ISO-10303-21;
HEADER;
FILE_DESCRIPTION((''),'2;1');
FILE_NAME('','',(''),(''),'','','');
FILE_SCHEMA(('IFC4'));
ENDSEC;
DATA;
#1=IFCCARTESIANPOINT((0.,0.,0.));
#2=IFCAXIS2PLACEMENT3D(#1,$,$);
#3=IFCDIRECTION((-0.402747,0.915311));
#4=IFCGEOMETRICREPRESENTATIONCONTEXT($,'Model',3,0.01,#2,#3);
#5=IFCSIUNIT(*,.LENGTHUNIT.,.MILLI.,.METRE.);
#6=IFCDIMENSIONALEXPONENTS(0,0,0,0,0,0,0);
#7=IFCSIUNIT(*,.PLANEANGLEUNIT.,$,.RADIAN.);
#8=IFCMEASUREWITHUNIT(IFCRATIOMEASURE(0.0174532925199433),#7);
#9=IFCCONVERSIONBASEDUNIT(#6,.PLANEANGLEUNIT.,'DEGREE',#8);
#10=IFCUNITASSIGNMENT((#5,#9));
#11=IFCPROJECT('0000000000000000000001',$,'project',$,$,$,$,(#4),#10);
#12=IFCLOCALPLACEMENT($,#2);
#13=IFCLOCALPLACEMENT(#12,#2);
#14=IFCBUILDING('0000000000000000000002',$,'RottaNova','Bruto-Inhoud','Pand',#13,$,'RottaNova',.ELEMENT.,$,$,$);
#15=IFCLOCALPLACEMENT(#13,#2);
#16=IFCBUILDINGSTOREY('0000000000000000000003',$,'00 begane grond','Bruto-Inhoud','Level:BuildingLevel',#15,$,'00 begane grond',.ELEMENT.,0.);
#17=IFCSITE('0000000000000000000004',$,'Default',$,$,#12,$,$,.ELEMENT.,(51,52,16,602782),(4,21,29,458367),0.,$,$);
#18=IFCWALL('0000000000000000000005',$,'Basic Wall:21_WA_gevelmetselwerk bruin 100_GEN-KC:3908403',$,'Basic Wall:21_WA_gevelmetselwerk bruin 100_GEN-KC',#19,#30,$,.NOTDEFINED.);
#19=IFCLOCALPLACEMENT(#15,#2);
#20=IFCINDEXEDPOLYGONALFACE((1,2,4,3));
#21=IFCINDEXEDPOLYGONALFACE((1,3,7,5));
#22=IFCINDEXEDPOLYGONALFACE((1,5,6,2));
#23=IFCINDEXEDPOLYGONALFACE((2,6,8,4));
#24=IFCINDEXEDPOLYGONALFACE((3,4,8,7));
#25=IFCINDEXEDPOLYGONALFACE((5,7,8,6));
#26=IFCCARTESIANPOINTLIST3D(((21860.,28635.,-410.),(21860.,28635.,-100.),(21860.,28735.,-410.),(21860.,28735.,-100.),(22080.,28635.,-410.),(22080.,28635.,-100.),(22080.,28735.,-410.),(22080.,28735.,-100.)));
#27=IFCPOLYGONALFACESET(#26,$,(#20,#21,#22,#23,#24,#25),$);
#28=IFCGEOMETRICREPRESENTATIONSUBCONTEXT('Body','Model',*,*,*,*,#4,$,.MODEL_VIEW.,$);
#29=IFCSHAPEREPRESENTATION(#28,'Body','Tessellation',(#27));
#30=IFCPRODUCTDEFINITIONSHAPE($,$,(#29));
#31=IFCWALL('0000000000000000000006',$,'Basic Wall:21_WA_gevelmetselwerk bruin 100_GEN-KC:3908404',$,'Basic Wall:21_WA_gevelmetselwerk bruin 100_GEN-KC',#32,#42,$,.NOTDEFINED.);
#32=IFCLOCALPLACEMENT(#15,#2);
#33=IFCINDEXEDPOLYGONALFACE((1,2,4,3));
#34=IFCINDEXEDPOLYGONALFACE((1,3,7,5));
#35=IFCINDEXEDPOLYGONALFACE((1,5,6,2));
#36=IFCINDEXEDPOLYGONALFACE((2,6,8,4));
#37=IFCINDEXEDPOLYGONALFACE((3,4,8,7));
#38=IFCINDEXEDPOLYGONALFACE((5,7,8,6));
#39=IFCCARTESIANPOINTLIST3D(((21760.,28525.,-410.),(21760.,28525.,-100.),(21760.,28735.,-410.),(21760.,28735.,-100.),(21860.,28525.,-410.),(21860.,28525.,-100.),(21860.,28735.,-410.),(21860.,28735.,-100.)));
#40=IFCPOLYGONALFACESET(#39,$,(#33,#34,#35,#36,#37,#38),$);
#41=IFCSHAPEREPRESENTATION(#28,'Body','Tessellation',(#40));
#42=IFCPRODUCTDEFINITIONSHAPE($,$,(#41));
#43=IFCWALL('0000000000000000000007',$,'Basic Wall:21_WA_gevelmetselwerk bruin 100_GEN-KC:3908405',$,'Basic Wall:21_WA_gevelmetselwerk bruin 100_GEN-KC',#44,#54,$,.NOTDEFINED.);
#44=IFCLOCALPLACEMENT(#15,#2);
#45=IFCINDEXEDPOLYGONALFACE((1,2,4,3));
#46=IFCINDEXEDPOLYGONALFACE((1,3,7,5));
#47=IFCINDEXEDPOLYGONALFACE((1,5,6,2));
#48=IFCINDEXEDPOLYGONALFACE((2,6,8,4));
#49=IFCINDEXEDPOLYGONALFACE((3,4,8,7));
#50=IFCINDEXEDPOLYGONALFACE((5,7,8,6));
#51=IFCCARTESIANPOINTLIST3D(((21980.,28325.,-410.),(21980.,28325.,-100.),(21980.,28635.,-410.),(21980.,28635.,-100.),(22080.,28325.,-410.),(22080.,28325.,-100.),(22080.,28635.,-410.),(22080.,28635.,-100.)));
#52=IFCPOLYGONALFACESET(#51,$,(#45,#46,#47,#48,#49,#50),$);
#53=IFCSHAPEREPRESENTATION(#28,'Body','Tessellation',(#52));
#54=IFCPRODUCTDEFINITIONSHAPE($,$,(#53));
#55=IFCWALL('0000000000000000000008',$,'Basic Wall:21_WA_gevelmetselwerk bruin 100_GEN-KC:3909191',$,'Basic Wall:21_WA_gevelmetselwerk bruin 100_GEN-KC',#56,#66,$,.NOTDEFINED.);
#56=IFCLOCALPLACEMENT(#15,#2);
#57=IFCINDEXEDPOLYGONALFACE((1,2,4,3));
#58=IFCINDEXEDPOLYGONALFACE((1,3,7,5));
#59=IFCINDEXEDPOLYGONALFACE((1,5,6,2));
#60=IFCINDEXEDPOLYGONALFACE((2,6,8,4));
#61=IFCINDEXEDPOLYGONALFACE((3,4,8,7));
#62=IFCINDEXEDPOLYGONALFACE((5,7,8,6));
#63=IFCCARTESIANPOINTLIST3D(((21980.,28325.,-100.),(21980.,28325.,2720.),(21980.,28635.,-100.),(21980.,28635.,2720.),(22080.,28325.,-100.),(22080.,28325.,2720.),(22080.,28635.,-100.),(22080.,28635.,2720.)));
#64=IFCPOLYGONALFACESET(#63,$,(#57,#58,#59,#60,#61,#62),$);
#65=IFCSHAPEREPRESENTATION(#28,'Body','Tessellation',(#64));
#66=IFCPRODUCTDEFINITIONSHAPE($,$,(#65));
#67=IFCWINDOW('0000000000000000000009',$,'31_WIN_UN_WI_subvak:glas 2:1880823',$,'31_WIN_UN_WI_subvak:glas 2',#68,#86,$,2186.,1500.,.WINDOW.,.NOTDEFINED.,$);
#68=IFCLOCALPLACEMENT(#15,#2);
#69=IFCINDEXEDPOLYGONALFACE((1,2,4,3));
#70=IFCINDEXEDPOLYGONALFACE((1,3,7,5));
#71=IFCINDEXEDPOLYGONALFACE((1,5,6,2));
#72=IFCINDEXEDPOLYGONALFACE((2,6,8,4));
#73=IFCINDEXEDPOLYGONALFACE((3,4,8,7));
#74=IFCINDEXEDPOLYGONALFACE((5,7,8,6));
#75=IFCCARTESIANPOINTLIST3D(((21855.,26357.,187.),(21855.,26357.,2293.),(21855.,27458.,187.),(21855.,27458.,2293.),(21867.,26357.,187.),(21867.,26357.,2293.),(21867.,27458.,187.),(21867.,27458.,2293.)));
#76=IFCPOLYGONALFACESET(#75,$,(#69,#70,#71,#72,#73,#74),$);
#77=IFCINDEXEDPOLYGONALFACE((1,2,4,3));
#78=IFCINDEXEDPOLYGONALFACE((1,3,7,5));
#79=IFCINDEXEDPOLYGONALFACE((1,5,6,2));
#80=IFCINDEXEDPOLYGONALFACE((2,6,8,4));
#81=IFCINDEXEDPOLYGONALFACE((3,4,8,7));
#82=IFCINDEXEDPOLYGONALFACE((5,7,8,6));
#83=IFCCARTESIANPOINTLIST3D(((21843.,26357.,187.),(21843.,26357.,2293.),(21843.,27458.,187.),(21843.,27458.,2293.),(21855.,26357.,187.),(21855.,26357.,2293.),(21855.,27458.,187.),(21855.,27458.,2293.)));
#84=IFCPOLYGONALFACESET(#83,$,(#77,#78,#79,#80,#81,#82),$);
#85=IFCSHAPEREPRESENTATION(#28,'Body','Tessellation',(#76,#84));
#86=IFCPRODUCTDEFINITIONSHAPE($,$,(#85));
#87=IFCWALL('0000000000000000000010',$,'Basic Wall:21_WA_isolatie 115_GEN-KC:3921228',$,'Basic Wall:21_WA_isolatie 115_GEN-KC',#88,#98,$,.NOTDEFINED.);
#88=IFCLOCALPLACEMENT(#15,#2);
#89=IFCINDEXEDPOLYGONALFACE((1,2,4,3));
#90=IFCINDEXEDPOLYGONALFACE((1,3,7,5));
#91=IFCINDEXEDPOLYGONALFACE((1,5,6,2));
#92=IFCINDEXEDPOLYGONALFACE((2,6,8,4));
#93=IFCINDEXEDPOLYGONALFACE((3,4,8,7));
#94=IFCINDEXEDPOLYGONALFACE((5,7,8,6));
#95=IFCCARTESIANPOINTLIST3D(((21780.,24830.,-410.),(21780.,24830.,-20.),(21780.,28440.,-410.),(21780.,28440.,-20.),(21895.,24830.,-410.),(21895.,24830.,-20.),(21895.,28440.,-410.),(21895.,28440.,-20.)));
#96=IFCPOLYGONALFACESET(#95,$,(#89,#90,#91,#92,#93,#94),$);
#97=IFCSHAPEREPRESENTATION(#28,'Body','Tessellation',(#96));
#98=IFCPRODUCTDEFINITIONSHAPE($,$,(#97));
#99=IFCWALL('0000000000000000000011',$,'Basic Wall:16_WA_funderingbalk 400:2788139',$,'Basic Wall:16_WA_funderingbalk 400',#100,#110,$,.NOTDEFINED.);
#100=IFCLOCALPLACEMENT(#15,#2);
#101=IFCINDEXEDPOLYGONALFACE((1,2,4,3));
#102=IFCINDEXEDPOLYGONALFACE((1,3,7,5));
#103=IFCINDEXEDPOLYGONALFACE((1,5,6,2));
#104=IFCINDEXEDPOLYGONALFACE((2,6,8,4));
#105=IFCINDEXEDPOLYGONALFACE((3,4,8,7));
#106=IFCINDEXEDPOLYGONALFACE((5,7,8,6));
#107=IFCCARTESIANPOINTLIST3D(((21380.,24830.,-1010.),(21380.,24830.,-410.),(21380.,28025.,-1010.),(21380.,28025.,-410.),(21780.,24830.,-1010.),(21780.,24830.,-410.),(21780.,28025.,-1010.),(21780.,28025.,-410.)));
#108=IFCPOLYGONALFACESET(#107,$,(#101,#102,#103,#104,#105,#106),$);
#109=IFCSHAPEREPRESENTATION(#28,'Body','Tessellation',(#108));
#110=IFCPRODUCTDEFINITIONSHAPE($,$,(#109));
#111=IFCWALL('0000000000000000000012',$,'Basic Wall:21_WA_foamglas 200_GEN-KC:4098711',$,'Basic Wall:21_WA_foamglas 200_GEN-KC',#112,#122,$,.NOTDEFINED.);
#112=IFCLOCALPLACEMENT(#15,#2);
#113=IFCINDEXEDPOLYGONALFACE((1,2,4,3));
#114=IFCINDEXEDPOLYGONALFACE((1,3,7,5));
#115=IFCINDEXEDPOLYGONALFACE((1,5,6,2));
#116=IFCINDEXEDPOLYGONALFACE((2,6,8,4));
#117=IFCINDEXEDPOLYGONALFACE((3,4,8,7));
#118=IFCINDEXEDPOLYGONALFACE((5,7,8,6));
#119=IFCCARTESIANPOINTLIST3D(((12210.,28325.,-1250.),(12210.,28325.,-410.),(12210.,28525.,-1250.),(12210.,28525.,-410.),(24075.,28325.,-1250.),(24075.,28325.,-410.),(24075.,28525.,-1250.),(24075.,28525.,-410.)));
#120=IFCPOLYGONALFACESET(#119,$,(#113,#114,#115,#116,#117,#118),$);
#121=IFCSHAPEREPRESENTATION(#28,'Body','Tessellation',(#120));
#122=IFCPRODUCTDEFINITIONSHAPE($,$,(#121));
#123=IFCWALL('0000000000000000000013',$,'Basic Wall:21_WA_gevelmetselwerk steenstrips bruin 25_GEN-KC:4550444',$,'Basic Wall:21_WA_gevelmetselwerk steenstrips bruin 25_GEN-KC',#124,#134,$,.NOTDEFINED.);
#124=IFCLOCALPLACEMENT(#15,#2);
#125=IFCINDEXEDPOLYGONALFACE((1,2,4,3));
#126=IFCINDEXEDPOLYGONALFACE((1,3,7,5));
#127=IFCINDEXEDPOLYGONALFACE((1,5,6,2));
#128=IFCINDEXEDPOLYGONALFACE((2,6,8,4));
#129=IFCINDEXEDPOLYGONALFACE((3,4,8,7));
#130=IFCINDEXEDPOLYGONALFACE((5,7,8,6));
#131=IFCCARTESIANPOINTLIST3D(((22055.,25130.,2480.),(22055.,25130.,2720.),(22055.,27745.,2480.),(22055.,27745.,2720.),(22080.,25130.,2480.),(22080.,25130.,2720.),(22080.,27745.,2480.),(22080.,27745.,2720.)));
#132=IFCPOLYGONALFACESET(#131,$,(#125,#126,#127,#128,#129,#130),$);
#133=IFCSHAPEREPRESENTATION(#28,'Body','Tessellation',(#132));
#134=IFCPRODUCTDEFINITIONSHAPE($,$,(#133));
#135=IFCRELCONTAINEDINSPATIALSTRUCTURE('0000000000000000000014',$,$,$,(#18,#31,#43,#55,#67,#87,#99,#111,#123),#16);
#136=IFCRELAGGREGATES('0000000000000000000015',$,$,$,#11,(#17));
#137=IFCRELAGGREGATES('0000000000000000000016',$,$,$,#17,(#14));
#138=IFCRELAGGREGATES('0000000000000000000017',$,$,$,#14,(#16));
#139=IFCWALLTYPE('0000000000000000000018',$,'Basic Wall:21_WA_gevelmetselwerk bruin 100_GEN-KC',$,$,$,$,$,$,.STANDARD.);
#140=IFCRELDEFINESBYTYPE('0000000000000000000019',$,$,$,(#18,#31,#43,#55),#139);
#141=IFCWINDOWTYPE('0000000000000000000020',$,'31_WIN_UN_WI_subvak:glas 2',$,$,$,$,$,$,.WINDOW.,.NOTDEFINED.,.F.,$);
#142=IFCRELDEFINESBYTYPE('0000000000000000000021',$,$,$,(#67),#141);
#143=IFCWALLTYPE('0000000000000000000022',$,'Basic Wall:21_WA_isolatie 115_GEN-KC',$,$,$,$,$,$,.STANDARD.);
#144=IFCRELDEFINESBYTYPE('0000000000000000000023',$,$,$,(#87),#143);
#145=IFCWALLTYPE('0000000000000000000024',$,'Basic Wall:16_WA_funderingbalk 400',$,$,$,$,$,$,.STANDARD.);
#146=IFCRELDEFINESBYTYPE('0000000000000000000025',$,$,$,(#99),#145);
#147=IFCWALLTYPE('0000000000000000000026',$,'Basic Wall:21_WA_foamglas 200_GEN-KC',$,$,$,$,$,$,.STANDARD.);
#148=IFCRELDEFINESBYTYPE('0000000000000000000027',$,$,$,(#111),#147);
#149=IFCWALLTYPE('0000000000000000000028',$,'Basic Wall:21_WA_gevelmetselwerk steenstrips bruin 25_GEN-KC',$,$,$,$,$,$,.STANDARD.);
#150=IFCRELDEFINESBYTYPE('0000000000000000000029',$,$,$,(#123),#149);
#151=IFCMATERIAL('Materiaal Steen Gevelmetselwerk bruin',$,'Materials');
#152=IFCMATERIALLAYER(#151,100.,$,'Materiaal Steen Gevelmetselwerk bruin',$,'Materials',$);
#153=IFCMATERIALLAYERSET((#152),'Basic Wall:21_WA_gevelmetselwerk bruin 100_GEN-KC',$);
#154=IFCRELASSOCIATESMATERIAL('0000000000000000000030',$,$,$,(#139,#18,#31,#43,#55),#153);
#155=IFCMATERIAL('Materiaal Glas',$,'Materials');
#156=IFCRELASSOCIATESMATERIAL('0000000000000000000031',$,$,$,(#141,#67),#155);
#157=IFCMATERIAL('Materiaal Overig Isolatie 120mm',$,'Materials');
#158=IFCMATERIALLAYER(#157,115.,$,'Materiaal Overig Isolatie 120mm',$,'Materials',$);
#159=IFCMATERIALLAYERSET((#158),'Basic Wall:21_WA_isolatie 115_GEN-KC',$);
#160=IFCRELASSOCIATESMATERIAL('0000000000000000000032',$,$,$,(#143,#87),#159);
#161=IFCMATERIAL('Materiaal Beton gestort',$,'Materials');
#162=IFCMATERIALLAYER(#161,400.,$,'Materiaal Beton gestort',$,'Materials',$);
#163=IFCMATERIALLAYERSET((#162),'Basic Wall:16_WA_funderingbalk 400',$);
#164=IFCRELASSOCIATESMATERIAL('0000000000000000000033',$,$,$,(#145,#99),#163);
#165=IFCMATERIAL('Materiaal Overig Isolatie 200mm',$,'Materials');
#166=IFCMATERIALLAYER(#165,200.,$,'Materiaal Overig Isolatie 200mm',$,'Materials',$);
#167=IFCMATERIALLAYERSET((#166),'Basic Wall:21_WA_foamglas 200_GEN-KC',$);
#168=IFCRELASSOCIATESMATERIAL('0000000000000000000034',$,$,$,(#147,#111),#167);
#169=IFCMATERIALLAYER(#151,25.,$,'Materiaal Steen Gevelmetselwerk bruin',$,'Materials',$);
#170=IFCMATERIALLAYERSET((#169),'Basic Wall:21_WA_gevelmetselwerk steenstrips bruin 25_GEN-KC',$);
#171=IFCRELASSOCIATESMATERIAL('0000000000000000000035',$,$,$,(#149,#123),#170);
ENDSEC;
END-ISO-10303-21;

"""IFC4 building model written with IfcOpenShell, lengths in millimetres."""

from ifc_helpers import new_model, entity, si_unit, converted_unit, direction, frame, frame_2d, origin, origin_2d_with_axis, place, context, subcontext, project, spatial, rectangle, extrude, source, transform, mapped, material, layer, layer_set, type_object, type_shapes, element, save


model = new_model("IFC4")

# Units and contexts
model_context = context("Model", 3, precision=0.01, world=origin(), true_north=direction((-0.402747, 0.915311)))
body_context = subcontext(model_context, "Body", "Model", "MODEL_VIEW")
ifc_project = project(units=[si_unit("LENGTHUNIT", "METRE", prefix="MILLI"), converted_unit("PLANEANGLEUNIT", "DEGREE", entity("IfcRatioMeasure", 0.0174532925199433), si_unit("PLANEANGLEUNIT", "RADIAN"), dimensions=[0, 0, 0, 0, 0, 0, 0])], contexts=[model_context])

# Site, building, storey
site_placement = place(None, origin())
site = spatial("IfcSite", under=ifc_project, at=site_placement, Name="Default", CompositionType="ELEMENT", RefLatitude=(51, 52, 16, 602782), RefLongitude=(4, 21, 29, 458367), RefElevation=0.0)
building_placement = place(site_placement, origin())
building = spatial("IfcBuilding", under=site, at=building_placement, Name="RottaNova", Description="Bruto-Inhoud", ObjectType="Pand", LongName="RottaNova", CompositionType="ELEMENT")
storey_placement = place(building_placement, origin())
storey = spatial("IfcBuildingStorey", under=building, at=storey_placement, Name="00 begane grond", Description="Bruto-Inhoud", ObjectType="Level:BuildingLevel", LongName="00 begane grond", CompositionType="ELEMENT", Elevation=0.0)

# Walls
ifc_material_1 = material(Name="Materiaal Steen Gevelmetselwerk bruin", Category="Materials")
ifc_layer_1 = layer(ifc_material_1, 100.0, Name="Materiaal Steen Gevelmetselwerk bruin", Category="Materials")
ifc_layer_set_1 = layer_set([ifc_layer_1], Name="Basic Wall:21_WA_gevelmetselwerk bruin 100_GEN-KC")
wall_type_1 = type_object("IfcWallType", Name="Basic Wall:21_WA_gevelmetselwerk bruin 100_GEN-KC", PredefinedType="STANDARD", material=ifc_layer_set_1)
wall_1_placement = place(storey_placement, frame((22080.0, 28685.0, -410.0), z_axis=(0.0, 0.0, 1.0), x_axis=(-1.0, 0.0, 0.0)))
element("IfcWall", 1, at=wall_1_placement, inside=storey, type_object=wall_type_1, material=ifc_layer_set_1, Name="Basic Wall:21_WA_gevelmetselwerk bruin 100_GEN-KC:3908403", ObjectType="Basic Wall:21_WA_gevelmetselwerk bruin 100_GEN-KC", PredefinedType="NOTDEFINED", context=body_context, shape_type="SweptSolid", body=[
    extrude(rectangle(XDim=220.0, YDim=100.0, at=frame_2d((110.0, 0.0), x_axis=(-1.0, 0.0))), origin(), (0.0, 0.0, 1.0), 310.0),
])
wall_2_placement = place(storey_placement, frame((21810.0, 28735.0, -410.0), z_axis=(0.0, 0.0, 1.0), x_axis=(0.0, -1.0, 0.0)))
element("IfcWall", 2, at=wall_2_placement, inside=storey, type_object=wall_type_1, material=ifc_layer_set_1, Name="Basic Wall:21_WA_gevelmetselwerk bruin 100_GEN-KC:3908404", ObjectType="Basic Wall:21_WA_gevelmetselwerk bruin 100_GEN-KC", PredefinedType="NOTDEFINED", context=body_context, shape_type="SweptSolid", body=[
    extrude(rectangle(XDim=210.0, YDim=100.0, at=frame_2d((105.0, 0.0), x_axis=(-1.0, 0.0))), origin(), (0.0, 0.0, 1.0), 310.0),
])
wall_3_placement = place(storey_placement, frame((22030.0, 28325.0, -410.0), z_axis=(0.0, 0.0, 1.0), x_axis=(0.0, 1.0, 0.0)))
element("IfcWall", 3, at=wall_3_placement, inside=storey, type_object=wall_type_1, material=ifc_layer_set_1, Name="Basic Wall:21_WA_gevelmetselwerk bruin 100_GEN-KC:3908405", ObjectType="Basic Wall:21_WA_gevelmetselwerk bruin 100_GEN-KC", PredefinedType="NOTDEFINED", context=body_context, shape_type="SweptSolid", body=[
    extrude(rectangle(XDim=310.0, YDim=100.0, at=frame_2d((155.0, 0.0), x_axis=(-1.0, 0.0))), origin(), (0.0, 0.0, 1.0), 310.0),
])
wall_4_placement = place(storey_placement, frame((22030.0, 28325.0, -100.0), z_axis=(0.0, 0.0, 1.0), x_axis=(0.0, 1.0, 0.0)))
element("IfcWall", 4, at=wall_4_placement, inside=storey, type_object=wall_type_1, material=ifc_layer_set_1, Name="Basic Wall:21_WA_gevelmetselwerk bruin 100_GEN-KC:3909191", ObjectType="Basic Wall:21_WA_gevelmetselwerk bruin 100_GEN-KC", PredefinedType="NOTDEFINED", context=body_context, shape_type="SweptSolid", body=[
    extrude(rectangle(XDim=310.0, YDim=100.0, at=frame_2d((155.0, 0.0), x_axis=(-1.0, 0.0))), origin(), (0.0, 0.0, 1.0), 2820.0),
])

# Window
ifc_material_2 = material(Name="Materiaal Glas", Category="Materials")
window_type = type_object("IfcWindowType", Name="31_WIN_UN_WI_subvak:glas 2", ParameterTakesPrecedence=False, PartitioningType="NOTDEFINED", PredefinedType="WINDOW", material=ifc_material_2)
shared_shape_1 = source(origin(), body_context, "Body", "SweptSolid", [
    extrude(rectangle(XDim=12.0, YDim=1101.0, at=frame_2d((0.0, 0.0), x_axis=(1.0, 0.0))), frame((0.0, 6.0, 0.0), z_axis=(0.0, 0.0, 1.0), x_axis=(0.0, -1.0, 0.0)), (0.0, 0.0, 1.0), 2106.0),
    extrude(rectangle(XDim=12.0, YDim=1101.0, at=origin_2d_with_axis()), frame((0.0, -6.0, 0.0), z_axis=(0.0, 0.0, 1.0), x_axis=(0.0, -1.0, 0.0)), (0.0, 0.0, 1.0), 2106.0),
])
type_shapes(window_type, [shared_shape_1])
window_placement = place(storey_placement, frame((21855.0, 26907.5, 187.0), z_axis=(0.0, 0.0, 1.0), x_axis=(0.0, -1.0, 0.0)))
element("IfcWindow", 5, at=window_placement, inside=storey, type_object=window_type, material=ifc_material_2, Name="31_WIN_UN_WI_subvak:glas 2:1880823", ObjectType="31_WIN_UN_WI_subvak:glas 2", OverallHeight=2186.0, OverallWidth=1500.0, PartitioningType="NOTDEFINED", PredefinedType="WINDOW", context=body_context, shape_type="MappedRepresentation", body=[
    mapped(shared_shape_1, transform((0.0, 0.0, 0.0), scale=1.0)),
])

# Walls
ifc_material_3 = material(Name="Materiaal Overig Isolatie 120mm", Category="Materials")
ifc_layer_2 = layer(ifc_material_3, 115.0, Name="Materiaal Overig Isolatie 120mm", Category="Materials")
ifc_layer_set_2 = layer_set([ifc_layer_2], Name="Basic Wall:21_WA_isolatie 115_GEN-KC")
wall_type_2 = type_object("IfcWallType", Name="Basic Wall:21_WA_isolatie 115_GEN-KC", PredefinedType="STANDARD", material=ifc_layer_set_2)
wall_5_placement = place(storey_placement, frame((21837.5, 28440.0, -410.0), z_axis=(0.0, 0.0, 1.0), x_axis=(0.0, -1.0, 0.0)))
element("IfcWall", 6, at=wall_5_placement, inside=storey, type_object=wall_type_2, material=ifc_layer_set_2, Name="Basic Wall:21_WA_isolatie 115_GEN-KC:3921228", ObjectType="Basic Wall:21_WA_isolatie 115_GEN-KC", PredefinedType="NOTDEFINED", context=body_context, shape_type="SweptSolid", body=[
    extrude(rectangle(XDim=3610.0, YDim=115.0, at=frame_2d((1805.0, 0.0), x_axis=(-1.0, 0.0))), origin(), (0.0, 0.0, 1.0), 390.0),
])
ifc_material_4 = material(Name="Materiaal Beton gestort", Category="Materials")
ifc_layer_3 = layer(ifc_material_4, 400.0, Name="Materiaal Beton gestort", Category="Materials")
ifc_layer_set_3 = layer_set([ifc_layer_3], Name="Basic Wall:16_WA_funderingbalk 400")
wall_type_3 = type_object("IfcWallType", Name="Basic Wall:16_WA_funderingbalk 400", PredefinedType="STANDARD", material=ifc_layer_set_3)
wall_6_placement = place(storey_placement, frame((21580.0, 28025.0, -1010.0), z_axis=(0.0, 0.0, 1.0), x_axis=(0.0, -1.0, 0.0)))
element("IfcWall", 7, at=wall_6_placement, inside=storey, type_object=wall_type_3, material=ifc_layer_set_3, Name="Basic Wall:16_WA_funderingbalk 400:2788139", ObjectType="Basic Wall:16_WA_funderingbalk 400", PredefinedType="NOTDEFINED", context=body_context, shape_type="SweptSolid", body=[
    extrude(rectangle(XDim=3195.0, YDim=400.0, at=frame_2d((1597.5, 0.0), x_axis=(-1.0, 0.0))), origin(), (0.0, 0.0, 1.0), 600.0),
])
ifc_material_5 = material(Name="Materiaal Overig Isolatie 200mm", Category="Materials")
ifc_layer_4 = layer(ifc_material_5, 200.0, Name="Materiaal Overig Isolatie 200mm", Category="Materials")
ifc_layer_set_4 = layer_set([ifc_layer_4], Name="Basic Wall:21_WA_foamglas 200_GEN-KC")
wall_type_4 = type_object("IfcWallType", Name="Basic Wall:21_WA_foamglas 200_GEN-KC", PredefinedType="STANDARD", material=ifc_layer_set_4)
wall_7_placement = place(storey_placement, frame((24075.0, 28425.0, -1250.0), z_axis=(0.0, 0.0, 1.0), x_axis=(-1.0, 0.0, 0.0)))
element("IfcWall", 8, at=wall_7_placement, inside=storey, type_object=wall_type_4, material=ifc_layer_set_4, Name="Basic Wall:21_WA_foamglas 200_GEN-KC:4098711", ObjectType="Basic Wall:21_WA_foamglas 200_GEN-KC", PredefinedType="NOTDEFINED", context=body_context, shape_type="SweptSolid", body=[
    extrude(rectangle(XDim=11865.0, YDim=200.0, at=frame_2d((5932.5, 0.0), x_axis=(-1.0, 0.0))), origin(), (0.0, 0.0, 1.0), 840.0),
])
ifc_layer_5 = layer(ifc_material_1, 25.0, Name="Materiaal Steen Gevelmetselwerk bruin", Category="Materials")
ifc_layer_set_5 = layer_set([ifc_layer_5], Name="Basic Wall:21_WA_gevelmetselwerk steenstrips bruin 25_GEN-KC")
wall_type_5 = type_object("IfcWallType", Name="Basic Wall:21_WA_gevelmetselwerk steenstrips bruin 25_GEN-KC", PredefinedType="STANDARD", material=ifc_layer_set_5)
wall_8_placement = place(storey_placement, frame((22067.5, 27745.0, 2480.0), z_axis=(0.0, 0.0, 1.0), x_axis=(0.0, -1.0, 0.0)))
element("IfcWall", 9, at=wall_8_placement, inside=storey, type_object=wall_type_5, material=ifc_layer_set_5, Name="Basic Wall:21_WA_gevelmetselwerk steenstrips bruin 25_GEN-KC:4550444", ObjectType="Basic Wall:21_WA_gevelmetselwerk steenstrips bruin 25_GEN-KC", PredefinedType="NOTDEFINED", context=body_context, shape_type="SweptSolid", body=[
    extrude(rectangle(XDim=2615.0, YDim=25.0, at=frame_2d((1307.5, 0.0), x_axis=(-1.0, 0.0))), origin(), (0.0, 0.0, 1.0), 240.0),
])

save(model, "model.ifc")
